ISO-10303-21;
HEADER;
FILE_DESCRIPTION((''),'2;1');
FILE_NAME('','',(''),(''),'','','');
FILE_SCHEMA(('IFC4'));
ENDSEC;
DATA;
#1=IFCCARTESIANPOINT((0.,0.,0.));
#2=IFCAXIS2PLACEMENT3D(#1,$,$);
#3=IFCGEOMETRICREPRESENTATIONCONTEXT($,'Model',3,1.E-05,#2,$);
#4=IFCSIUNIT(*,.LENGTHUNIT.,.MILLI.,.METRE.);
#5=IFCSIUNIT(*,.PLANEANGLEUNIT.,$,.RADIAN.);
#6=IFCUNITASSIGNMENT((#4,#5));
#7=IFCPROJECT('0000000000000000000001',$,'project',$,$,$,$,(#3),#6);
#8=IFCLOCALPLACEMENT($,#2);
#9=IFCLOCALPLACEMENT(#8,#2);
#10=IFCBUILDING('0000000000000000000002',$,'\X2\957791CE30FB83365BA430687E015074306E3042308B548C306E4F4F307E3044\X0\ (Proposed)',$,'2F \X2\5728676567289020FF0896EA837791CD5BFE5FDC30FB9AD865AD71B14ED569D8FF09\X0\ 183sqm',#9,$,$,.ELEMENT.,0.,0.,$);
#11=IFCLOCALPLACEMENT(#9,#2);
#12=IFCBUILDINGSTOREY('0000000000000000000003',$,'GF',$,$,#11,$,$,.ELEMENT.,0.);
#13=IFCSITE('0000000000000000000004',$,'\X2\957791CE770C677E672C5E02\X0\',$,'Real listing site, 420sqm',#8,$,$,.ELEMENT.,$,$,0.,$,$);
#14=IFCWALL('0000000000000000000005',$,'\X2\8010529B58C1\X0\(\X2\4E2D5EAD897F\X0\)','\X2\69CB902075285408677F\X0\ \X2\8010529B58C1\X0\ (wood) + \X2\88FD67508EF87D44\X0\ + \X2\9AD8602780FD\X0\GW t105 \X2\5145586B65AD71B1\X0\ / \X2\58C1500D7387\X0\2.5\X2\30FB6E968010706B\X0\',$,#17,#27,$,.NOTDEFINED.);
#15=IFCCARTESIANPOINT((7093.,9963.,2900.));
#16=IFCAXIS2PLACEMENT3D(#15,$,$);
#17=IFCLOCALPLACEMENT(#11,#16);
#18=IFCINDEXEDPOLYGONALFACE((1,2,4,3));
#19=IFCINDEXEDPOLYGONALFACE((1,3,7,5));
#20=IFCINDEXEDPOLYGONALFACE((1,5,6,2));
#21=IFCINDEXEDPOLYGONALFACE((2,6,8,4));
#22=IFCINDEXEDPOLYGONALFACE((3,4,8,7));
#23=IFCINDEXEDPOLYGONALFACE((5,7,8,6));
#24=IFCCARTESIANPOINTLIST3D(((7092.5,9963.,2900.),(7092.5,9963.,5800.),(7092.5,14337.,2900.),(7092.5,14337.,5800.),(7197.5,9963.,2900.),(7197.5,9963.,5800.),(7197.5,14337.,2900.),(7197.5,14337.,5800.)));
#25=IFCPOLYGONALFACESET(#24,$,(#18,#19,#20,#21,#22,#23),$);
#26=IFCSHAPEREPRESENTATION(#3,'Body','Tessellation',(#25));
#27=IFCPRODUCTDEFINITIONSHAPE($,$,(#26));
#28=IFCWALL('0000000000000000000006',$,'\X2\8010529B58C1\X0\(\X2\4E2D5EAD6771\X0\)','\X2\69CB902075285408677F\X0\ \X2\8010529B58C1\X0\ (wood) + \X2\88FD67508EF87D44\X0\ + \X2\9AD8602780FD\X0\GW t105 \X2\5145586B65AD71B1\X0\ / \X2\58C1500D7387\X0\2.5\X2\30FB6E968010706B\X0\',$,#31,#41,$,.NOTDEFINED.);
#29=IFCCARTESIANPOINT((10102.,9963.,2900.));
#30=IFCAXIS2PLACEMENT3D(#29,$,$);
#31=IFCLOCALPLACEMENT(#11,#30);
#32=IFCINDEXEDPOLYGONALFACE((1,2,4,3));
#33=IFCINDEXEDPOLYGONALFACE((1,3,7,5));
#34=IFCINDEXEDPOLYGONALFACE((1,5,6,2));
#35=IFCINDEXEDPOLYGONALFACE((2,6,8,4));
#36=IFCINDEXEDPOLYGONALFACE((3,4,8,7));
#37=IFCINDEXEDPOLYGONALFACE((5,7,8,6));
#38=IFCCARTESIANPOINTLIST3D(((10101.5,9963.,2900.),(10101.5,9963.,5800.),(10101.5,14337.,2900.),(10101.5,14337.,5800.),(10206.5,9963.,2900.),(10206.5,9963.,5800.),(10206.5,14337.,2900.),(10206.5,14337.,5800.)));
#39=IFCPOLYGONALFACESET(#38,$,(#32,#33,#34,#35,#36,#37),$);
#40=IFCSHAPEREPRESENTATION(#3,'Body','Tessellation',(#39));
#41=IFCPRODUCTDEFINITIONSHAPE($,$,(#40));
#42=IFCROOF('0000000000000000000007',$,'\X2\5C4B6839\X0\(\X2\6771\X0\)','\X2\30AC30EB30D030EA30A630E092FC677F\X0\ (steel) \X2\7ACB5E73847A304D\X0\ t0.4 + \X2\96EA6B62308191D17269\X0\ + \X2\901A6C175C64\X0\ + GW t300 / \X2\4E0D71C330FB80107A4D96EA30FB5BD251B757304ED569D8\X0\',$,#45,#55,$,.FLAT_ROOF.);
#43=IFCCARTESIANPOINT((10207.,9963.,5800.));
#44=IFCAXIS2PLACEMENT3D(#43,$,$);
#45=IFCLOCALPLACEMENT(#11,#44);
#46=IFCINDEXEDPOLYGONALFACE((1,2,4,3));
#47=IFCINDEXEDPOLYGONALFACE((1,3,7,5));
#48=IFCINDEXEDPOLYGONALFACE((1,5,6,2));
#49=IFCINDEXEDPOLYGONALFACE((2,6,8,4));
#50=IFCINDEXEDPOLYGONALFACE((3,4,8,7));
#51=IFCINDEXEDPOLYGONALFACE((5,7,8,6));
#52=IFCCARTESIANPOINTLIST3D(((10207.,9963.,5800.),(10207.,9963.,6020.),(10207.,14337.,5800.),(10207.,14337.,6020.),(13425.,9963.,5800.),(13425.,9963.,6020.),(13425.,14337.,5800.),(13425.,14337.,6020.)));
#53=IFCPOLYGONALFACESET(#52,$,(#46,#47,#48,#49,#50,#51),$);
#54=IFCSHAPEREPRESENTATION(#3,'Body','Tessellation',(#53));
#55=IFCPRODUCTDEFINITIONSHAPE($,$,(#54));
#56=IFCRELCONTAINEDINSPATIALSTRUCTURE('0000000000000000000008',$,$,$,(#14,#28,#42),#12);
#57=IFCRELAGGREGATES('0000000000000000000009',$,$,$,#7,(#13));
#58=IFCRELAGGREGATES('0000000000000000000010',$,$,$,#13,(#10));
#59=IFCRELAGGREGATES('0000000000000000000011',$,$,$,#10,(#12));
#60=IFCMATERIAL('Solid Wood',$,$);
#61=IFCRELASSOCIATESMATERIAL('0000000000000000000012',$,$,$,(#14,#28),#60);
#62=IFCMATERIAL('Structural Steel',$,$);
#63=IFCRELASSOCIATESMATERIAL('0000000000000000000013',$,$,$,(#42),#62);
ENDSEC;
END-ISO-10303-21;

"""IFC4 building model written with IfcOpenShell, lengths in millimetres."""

from ifc_helpers import new_model, si_unit, frame, frame_2d, origin, place, context, project, spatial, rectangle, extrude, material, element, save


model = new_model("IFC4")

# Units and contexts
model_context = context("Model", 3, precision=1e-05, world=origin())
ifc_project = project(units=[si_unit("LENGTHUNIT", "METRE", prefix="MILLI"), si_unit("PLANEANGLEUNIT", "RADIAN")], contexts=[model_context])

# Site, building, storey
site_placement = place(None, origin())
site = spatial("IfcSite", under=ifc_project, at=site_placement, Name="長野県松本市", ObjectType="Real listing site, 420sqm", CompositionType="ELEMENT", RefElevation=0.0)
building_placement = place(site_placement, origin())
building = spatial("IfcBuilding", under=site, at=building_placement, Name="長野・茶室と縁側のある和の住まい (Proposed)", ObjectType="2F 在来木造（雪荷重対応・高断熱仕様） 183sqm", CompositionType="ELEMENT", ElevationOfRefHeight=0.0, ElevationOfTerrain=0.0)
storey_placement = place(building_placement, origin())
storey = spatial("IfcBuildingStorey", under=building, at=storey_placement, Name="GF", CompositionType="ELEMENT", Elevation=0.0)

# Shared definitions
ifc_material_1 = material(Name="Solid Wood")

# Walls
wall_1_placement = place(storey_placement, frame((7093.0, 9963.0, 2900.0)))
element("IfcWall", 1, at=wall_1_placement, inside=storey, material=ifc_material_1, Name="耐力壁(中庭西)", Description="構造用合板 耐力壁 (wood) + 製材軸組 + 高性能GW t105 充填断熱 / 壁倍率2.5・準耐火", PredefinedType="NOTDEFINED", context=model_context, shape_type="SweptSolid", body=[
    extrude(rectangle(XDim=105.0, YDim=4374.0, at=frame_2d((52.0, 2187.0))), frame((7093.0, 9963.0, 2900.0)), (0.0, 0.0, 1.0), 2900.0),
])
wall_2_placement = place(storey_placement, frame((10102.0, 9963.0, 2900.0)))
element("IfcWall", 2, at=wall_2_placement, inside=storey, material=ifc_material_1, Name="耐力壁(中庭東)", Description="構造用合板 耐力壁 (wood) + 製材軸組 + 高性能GW t105 充填断熱 / 壁倍率2.5・準耐火", PredefinedType="NOTDEFINED", context=model_context, shape_type="SweptSolid", body=[
    extrude(rectangle(XDim=105.0, YDim=4374.0, at=frame_2d((52.0, 2187.0))), frame((10102.0, 9963.0, 2900.0)), (0.0, 0.0, 1.0), 2900.0),
])

# Roof
ifc_material_2 = material(Name="Structural Steel")
for number, where, name in (
    (3, (10207.0, 9963.0, 5800.0), "屋根(東)"),
):
    element("IfcRoof", number, at=place(storey_placement, frame(where)), inside=storey, material=ifc_material_2, Name=name, Description="ガルバリウム鋼板 (steel) 立平葺き t0.4 + 雪止め金物 + 通気層 + GW t300 / 不燃・耐積雪・寒冷地仕様", PredefinedType="FLAT_ROOF", context=model_context, shape_type="SweptSolid", body=[
        extrude(rectangle(XDim=3218.0, YDim=4374.0, at=frame_2d((1609.0, 2187.0))), frame((10207.0, 9963.0, 5800.0)), (0.0, 0.0, 1.0), 220.0),
    ])

save(model, "model.ifc")
